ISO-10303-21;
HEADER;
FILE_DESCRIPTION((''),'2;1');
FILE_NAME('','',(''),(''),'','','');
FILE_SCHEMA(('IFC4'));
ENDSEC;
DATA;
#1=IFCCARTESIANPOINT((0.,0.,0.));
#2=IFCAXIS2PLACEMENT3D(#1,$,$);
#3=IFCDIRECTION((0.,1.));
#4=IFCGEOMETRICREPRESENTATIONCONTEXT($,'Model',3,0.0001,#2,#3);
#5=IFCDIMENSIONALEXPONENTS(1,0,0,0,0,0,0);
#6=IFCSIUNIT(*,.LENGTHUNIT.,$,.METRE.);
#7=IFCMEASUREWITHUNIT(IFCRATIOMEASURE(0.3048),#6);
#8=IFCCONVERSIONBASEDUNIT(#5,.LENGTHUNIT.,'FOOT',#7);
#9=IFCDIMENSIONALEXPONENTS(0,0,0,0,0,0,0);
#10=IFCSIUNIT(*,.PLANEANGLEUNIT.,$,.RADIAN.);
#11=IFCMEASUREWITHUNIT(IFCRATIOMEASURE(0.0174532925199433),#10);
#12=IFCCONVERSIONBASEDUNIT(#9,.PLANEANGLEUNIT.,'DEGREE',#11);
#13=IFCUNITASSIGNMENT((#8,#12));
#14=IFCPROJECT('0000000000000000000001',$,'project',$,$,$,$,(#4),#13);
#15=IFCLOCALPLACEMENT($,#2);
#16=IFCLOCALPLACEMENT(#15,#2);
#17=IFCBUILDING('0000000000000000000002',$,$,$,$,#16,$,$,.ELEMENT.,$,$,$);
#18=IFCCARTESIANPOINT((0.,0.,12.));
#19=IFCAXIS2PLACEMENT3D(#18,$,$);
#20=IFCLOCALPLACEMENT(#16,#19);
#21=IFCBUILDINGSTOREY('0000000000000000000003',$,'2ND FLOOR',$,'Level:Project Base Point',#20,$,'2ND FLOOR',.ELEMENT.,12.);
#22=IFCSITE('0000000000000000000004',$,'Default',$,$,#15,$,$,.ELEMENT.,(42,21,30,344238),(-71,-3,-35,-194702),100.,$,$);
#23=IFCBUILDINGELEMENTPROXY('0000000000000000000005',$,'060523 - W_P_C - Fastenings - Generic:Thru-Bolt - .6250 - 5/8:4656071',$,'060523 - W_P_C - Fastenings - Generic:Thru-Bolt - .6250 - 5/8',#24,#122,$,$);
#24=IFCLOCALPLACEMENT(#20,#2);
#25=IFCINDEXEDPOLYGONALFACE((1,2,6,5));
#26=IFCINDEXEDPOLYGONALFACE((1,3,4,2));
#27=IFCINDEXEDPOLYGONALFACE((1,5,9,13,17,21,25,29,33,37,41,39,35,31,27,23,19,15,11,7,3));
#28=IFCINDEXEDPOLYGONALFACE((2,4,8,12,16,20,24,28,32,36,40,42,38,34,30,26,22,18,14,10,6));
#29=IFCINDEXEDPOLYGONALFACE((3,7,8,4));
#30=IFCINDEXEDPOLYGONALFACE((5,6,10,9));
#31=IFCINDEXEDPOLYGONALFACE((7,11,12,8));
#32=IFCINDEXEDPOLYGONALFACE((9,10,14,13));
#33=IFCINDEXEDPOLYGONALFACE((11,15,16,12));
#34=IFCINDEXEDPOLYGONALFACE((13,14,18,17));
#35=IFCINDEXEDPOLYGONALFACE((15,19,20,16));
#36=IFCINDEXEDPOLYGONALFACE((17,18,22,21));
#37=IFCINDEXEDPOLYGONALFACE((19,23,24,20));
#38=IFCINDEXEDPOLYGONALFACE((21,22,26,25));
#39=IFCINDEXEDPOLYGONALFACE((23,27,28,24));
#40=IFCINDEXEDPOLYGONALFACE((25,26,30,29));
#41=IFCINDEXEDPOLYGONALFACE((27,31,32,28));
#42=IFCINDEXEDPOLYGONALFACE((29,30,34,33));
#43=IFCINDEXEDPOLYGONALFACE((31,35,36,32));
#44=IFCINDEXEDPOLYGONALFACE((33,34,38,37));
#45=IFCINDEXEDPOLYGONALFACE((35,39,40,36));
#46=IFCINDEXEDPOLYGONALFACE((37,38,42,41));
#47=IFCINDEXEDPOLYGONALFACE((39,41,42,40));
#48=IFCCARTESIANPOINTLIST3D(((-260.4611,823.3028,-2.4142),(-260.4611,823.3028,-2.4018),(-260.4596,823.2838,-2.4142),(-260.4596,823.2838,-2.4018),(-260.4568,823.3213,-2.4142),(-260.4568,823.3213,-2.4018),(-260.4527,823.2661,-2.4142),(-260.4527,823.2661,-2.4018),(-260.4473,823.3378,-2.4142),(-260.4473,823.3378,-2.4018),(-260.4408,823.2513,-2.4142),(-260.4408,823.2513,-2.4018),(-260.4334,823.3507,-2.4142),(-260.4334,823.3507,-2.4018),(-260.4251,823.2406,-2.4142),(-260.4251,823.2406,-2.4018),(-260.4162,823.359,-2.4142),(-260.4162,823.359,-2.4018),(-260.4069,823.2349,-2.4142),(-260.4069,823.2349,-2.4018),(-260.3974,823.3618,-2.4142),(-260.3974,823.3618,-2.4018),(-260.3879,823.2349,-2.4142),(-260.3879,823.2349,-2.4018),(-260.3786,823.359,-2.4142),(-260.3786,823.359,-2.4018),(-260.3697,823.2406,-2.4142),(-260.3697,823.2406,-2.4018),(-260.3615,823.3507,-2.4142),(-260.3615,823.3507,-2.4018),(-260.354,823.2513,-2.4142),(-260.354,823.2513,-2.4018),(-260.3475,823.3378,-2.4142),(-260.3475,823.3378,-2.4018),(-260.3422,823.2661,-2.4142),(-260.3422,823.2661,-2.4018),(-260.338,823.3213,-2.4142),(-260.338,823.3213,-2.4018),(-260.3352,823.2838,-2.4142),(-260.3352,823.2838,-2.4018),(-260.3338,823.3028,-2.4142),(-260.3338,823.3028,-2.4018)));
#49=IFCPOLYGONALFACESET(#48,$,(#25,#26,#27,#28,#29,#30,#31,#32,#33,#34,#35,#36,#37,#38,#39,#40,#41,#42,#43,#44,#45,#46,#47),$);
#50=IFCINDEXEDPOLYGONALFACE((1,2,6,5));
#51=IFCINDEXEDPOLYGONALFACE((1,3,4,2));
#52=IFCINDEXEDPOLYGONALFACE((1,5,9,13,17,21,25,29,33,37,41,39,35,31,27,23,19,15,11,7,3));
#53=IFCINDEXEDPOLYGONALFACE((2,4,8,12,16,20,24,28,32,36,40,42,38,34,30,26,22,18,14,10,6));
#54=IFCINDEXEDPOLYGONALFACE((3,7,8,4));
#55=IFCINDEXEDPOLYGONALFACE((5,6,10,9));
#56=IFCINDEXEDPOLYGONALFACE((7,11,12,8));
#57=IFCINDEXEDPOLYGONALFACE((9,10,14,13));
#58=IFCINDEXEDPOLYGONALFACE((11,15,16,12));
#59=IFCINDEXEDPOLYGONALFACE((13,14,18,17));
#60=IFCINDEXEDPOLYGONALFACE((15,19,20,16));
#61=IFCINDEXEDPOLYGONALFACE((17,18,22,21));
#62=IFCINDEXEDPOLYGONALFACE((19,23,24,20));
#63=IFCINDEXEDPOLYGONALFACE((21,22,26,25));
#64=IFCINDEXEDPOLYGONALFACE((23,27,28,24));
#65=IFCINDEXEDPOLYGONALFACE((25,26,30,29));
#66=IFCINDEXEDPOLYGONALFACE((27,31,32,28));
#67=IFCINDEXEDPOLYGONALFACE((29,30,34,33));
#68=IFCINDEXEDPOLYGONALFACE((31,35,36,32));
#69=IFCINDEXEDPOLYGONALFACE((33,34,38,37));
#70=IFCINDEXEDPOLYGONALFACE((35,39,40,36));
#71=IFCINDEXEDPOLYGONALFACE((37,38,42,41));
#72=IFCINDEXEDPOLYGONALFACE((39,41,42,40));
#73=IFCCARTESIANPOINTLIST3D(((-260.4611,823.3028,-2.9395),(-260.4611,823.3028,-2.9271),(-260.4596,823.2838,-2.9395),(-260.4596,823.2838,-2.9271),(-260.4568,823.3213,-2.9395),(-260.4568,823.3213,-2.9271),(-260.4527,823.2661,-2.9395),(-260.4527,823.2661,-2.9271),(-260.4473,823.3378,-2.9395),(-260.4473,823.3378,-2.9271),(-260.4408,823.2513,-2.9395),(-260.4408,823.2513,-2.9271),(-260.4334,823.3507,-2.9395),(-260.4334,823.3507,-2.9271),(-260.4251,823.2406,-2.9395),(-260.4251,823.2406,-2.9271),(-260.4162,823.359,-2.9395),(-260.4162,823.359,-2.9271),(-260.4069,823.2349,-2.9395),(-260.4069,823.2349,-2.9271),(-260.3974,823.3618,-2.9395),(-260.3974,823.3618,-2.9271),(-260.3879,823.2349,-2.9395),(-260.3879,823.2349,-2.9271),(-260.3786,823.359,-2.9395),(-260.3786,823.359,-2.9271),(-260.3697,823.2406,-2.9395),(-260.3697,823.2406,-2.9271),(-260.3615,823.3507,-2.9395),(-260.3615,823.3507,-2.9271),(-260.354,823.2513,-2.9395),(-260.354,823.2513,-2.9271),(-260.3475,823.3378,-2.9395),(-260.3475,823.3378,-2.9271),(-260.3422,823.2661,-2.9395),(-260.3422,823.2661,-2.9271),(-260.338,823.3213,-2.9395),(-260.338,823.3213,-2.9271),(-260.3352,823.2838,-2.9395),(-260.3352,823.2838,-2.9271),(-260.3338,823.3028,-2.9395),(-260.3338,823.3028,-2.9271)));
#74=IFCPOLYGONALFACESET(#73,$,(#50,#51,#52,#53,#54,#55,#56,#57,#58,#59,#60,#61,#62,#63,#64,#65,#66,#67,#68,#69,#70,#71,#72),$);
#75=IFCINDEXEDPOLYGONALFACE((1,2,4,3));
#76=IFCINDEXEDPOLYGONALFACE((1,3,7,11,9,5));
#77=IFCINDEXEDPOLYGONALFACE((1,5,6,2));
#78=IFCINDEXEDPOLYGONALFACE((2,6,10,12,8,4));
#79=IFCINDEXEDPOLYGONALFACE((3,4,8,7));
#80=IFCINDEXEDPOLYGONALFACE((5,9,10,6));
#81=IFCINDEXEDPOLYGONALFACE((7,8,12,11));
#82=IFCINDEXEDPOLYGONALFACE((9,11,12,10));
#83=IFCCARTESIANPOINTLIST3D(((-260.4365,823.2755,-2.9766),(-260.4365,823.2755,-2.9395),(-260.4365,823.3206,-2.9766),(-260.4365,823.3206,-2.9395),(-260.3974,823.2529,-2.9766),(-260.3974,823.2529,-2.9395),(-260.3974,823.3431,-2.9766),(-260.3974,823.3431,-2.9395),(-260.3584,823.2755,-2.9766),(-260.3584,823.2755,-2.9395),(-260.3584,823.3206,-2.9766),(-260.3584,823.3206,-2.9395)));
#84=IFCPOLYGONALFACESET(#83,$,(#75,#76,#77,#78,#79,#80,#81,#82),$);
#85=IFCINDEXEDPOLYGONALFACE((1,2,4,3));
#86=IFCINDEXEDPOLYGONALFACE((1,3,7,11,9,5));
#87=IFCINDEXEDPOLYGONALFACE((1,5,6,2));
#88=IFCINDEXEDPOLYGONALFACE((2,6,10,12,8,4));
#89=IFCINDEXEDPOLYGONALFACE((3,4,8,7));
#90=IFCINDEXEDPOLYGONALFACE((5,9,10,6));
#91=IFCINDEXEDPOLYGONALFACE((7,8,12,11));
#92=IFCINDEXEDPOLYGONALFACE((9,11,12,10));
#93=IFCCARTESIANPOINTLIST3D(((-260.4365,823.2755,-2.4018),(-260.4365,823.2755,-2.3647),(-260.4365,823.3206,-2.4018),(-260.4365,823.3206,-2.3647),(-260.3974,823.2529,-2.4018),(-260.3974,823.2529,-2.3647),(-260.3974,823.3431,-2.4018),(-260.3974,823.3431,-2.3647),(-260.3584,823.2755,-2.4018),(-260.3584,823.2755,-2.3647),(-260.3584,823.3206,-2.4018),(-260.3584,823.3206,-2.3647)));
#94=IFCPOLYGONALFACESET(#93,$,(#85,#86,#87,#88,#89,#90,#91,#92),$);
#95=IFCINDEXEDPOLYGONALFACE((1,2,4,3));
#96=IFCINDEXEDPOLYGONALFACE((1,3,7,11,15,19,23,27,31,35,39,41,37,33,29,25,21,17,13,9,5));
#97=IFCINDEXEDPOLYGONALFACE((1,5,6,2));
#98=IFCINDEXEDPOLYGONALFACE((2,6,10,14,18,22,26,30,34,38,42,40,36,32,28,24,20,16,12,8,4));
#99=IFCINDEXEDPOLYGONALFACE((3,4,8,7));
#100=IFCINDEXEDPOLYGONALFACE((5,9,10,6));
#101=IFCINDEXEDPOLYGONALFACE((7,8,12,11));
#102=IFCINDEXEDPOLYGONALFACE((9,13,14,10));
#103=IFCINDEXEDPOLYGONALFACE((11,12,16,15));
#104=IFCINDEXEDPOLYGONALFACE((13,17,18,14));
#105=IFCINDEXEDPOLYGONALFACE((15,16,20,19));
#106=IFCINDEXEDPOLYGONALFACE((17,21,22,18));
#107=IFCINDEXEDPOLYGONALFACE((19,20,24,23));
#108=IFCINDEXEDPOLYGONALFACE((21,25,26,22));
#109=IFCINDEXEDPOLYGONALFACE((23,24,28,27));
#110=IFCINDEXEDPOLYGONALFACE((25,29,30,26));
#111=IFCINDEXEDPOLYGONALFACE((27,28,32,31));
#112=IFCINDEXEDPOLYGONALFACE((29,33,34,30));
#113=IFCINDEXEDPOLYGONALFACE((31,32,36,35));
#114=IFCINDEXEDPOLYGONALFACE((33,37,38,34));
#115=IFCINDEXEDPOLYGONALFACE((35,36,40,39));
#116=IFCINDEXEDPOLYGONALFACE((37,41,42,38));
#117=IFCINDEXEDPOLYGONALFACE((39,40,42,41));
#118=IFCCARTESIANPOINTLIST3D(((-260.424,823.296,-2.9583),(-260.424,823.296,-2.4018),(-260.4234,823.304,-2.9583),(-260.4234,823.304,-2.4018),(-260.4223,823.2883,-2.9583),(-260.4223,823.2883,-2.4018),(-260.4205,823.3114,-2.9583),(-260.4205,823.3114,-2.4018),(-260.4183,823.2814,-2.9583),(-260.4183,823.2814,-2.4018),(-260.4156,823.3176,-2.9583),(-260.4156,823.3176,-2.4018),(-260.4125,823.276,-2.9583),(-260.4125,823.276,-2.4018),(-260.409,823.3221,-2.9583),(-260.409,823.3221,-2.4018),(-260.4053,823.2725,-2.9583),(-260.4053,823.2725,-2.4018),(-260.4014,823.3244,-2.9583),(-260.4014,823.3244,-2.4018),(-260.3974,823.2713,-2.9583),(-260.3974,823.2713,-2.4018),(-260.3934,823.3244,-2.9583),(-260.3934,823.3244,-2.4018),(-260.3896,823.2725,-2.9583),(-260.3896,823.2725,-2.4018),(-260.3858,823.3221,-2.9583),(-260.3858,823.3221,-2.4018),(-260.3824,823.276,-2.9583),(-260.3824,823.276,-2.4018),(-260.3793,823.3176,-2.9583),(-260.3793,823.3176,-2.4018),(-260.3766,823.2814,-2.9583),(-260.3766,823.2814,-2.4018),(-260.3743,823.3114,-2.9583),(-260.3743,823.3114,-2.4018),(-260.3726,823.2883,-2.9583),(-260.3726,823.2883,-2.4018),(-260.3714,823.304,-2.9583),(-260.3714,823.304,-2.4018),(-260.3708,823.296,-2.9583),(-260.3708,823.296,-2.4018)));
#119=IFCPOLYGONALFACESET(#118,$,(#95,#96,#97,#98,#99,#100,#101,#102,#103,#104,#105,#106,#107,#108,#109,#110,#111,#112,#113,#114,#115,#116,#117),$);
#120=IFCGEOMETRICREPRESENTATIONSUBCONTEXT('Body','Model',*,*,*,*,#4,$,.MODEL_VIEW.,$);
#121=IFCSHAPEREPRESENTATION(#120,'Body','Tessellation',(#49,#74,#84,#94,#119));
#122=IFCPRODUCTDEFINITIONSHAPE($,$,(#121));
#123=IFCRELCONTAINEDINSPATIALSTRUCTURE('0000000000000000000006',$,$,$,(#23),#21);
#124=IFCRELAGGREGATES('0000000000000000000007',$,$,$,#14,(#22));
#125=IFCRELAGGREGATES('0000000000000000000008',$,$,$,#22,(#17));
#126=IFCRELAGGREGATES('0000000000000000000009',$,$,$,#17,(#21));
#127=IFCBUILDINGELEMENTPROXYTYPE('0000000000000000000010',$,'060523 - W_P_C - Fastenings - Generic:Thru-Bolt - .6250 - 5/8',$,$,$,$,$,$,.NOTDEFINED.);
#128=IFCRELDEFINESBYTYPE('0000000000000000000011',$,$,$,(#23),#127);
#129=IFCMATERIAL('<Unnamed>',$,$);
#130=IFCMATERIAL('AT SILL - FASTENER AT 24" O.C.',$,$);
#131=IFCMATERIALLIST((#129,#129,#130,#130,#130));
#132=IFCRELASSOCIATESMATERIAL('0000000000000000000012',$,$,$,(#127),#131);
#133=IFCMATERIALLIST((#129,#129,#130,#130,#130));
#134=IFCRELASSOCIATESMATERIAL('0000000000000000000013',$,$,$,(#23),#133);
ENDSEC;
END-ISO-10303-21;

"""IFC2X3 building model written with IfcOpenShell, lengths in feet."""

from ifc_helpers import new_model, entity, si_unit, converted_unit, direction, frame, frame_2d, origin, place, context, subcontext, project, spatial, polyline, circle, outline, extrude, source, transform, mapped, material, material_list, type_object, type_shapes, element, save


model = new_model("IFC2X3")

# Units and contexts
model_context = context("Model", 3, precision=0.0001, world=origin(), true_north=direction((0.0, 1.0)))
body_context = subcontext(model_context, "Body", "Model", "MODEL_VIEW")
ifc_project = project(units=[converted_unit("LENGTHUNIT", "FOOT", entity("IfcRatioMeasure", 0.3048), si_unit("LENGTHUNIT", "METRE"), dimensions=[1, 0, 0, 0, 0, 0, 0]), converted_unit("PLANEANGLEUNIT", "DEGREE", entity("IfcRatioMeasure", 0.0174532925199433), si_unit("PLANEANGLEUNIT", "RADIAN"), dimensions=[0, 0, 0, 0, 0, 0, 0])], contexts=[model_context])

# Site, building, storey
site_placement = place(None, origin())
site = spatial("IfcSite", under=ifc_project, at=site_placement, Name="Default", CompositionType="ELEMENT", RefLatitude=(42, 21, 30, 344238), RefLongitude=(-71, -3, -35, -194702), RefElevation=100.0)
building_placement = place(site_placement, origin())
building = spatial("IfcBuilding", under=site, at=building_placement, CompositionType="ELEMENT")
storey_placement = place(building_placement, frame((0.0, 0.0, 12.0)))
storey = spatial("IfcBuildingStorey", under=building, at=storey_placement, Name="2ND FLOOR", ObjectType="Level:Project Base Point", LongName="2ND FLOOR", CompositionType="ELEMENT", Elevation=12.0)

# Building element proxy
ifc_material_1 = material(Name="<Unnamed>")
ifc_material_2 = material(Name="AT SILL - FASTENER AT 24\" O.C.")
ifc_material_list_1 = material_list([ifc_material_1, ifc_material_1, ifc_material_2, ifc_material_2, ifc_material_2])
ifc_material_list_2 = material_list([ifc_material_1, ifc_material_1, ifc_material_2, ifc_material_2, ifc_material_2])
building_element_proxy_type_1 = type_object("IfcBuildingElementProxyType", Name="060523 - W_P_C - Fastenings - Generic:Thru-Bolt - .6250 - 5/8", PredefinedType="NOTDEFINED", material=ifc_material_list_2)
shared_shape_1 = source(origin(), body_context, "Body", "SweptSolid", [
    extrude(circle(Radius=0.0638, at=frame_2d((0.0, 0.0), x_axis=(1.0, 0.0))), frame((0.0, 0.0, 0.0), z_axis=(0.0, 0.0, 1.0), x_axis=(0.0, 1.0, 0.0)), (0.0, 0.0, 1.0), 0.0124),
    extrude(circle(Radius=0.0638, at=frame_2d((0.0, 0.0), x_axis=(1.0, 0.0))), frame((0.0, 0.0, -0.5253), z_axis=(0.0, 0.0, 1.0), x_axis=(0.0, 1.0, 0.0)), (0.0, 0.0, 1.0), 0.0124),
    extrude(outline(polyline([(-0.0226, -0.0391), (0.0226, -0.0391), (0.0451, 0.0), (0.0226, 0.0391), (-0.0226, 0.0391), (-0.0451, 0.0), (-0.0226, -0.0391)])), frame((0.0, 0.0, -0.5624), z_axis=(0.0, 0.0, 1.0), x_axis=(0.0, -1.0, 0.0)), (0.0, 0.0, 1.0), 0.0371),
    extrude(outline(polyline([(-0.0226, -0.0391), (0.0226, -0.0391), (0.0451, 0.0), (0.0226, 0.0391), (-0.0226, 0.0391), (-0.0451, 0.0), (-0.0226, -0.0391)])), frame((0.0, 0.0, 0.0124), z_axis=(0.0, 0.0, 1.0), x_axis=(0.866025, -0.5, 0.0)), (0.0, 0.0, 1.0), 0.0371),
    extrude(circle(Radius=0.0267, at=frame_2d((0.0, 0.0), x_axis=(1.0, 0.0))), frame((0.0, 0.0, -0.5442), z_axis=(0.0, 0.0, 1.0), x_axis=(0.0, -1.0, 0.0)), (0.0, 0.0, 1.0), 0.5565),
])
type_shapes(building_element_proxy_type_1, [shared_shape_1])
proxy_1_placement = place(storey_placement, frame((-260.3974, 823.298, -2.4142)))
element("IfcBuildingElementProxy", 1, at=proxy_1_placement, inside=storey, type_object=building_element_proxy_type_1, material=ifc_material_list_1, Name="060523 - W_P_C - Fastenings - Generic:Thru-Bolt - .6250 - 5/8:4656071", ObjectType="060523 - W_P_C - Fastenings - Generic:Thru-Bolt - .6250 - 5/8", context=body_context, shape_type="MappedRepresentation", body=[
    mapped(shared_shape_1, transform((0.0, 0.0, 0.0), scale=1.0)),
])

save(model, "model.ifc")
